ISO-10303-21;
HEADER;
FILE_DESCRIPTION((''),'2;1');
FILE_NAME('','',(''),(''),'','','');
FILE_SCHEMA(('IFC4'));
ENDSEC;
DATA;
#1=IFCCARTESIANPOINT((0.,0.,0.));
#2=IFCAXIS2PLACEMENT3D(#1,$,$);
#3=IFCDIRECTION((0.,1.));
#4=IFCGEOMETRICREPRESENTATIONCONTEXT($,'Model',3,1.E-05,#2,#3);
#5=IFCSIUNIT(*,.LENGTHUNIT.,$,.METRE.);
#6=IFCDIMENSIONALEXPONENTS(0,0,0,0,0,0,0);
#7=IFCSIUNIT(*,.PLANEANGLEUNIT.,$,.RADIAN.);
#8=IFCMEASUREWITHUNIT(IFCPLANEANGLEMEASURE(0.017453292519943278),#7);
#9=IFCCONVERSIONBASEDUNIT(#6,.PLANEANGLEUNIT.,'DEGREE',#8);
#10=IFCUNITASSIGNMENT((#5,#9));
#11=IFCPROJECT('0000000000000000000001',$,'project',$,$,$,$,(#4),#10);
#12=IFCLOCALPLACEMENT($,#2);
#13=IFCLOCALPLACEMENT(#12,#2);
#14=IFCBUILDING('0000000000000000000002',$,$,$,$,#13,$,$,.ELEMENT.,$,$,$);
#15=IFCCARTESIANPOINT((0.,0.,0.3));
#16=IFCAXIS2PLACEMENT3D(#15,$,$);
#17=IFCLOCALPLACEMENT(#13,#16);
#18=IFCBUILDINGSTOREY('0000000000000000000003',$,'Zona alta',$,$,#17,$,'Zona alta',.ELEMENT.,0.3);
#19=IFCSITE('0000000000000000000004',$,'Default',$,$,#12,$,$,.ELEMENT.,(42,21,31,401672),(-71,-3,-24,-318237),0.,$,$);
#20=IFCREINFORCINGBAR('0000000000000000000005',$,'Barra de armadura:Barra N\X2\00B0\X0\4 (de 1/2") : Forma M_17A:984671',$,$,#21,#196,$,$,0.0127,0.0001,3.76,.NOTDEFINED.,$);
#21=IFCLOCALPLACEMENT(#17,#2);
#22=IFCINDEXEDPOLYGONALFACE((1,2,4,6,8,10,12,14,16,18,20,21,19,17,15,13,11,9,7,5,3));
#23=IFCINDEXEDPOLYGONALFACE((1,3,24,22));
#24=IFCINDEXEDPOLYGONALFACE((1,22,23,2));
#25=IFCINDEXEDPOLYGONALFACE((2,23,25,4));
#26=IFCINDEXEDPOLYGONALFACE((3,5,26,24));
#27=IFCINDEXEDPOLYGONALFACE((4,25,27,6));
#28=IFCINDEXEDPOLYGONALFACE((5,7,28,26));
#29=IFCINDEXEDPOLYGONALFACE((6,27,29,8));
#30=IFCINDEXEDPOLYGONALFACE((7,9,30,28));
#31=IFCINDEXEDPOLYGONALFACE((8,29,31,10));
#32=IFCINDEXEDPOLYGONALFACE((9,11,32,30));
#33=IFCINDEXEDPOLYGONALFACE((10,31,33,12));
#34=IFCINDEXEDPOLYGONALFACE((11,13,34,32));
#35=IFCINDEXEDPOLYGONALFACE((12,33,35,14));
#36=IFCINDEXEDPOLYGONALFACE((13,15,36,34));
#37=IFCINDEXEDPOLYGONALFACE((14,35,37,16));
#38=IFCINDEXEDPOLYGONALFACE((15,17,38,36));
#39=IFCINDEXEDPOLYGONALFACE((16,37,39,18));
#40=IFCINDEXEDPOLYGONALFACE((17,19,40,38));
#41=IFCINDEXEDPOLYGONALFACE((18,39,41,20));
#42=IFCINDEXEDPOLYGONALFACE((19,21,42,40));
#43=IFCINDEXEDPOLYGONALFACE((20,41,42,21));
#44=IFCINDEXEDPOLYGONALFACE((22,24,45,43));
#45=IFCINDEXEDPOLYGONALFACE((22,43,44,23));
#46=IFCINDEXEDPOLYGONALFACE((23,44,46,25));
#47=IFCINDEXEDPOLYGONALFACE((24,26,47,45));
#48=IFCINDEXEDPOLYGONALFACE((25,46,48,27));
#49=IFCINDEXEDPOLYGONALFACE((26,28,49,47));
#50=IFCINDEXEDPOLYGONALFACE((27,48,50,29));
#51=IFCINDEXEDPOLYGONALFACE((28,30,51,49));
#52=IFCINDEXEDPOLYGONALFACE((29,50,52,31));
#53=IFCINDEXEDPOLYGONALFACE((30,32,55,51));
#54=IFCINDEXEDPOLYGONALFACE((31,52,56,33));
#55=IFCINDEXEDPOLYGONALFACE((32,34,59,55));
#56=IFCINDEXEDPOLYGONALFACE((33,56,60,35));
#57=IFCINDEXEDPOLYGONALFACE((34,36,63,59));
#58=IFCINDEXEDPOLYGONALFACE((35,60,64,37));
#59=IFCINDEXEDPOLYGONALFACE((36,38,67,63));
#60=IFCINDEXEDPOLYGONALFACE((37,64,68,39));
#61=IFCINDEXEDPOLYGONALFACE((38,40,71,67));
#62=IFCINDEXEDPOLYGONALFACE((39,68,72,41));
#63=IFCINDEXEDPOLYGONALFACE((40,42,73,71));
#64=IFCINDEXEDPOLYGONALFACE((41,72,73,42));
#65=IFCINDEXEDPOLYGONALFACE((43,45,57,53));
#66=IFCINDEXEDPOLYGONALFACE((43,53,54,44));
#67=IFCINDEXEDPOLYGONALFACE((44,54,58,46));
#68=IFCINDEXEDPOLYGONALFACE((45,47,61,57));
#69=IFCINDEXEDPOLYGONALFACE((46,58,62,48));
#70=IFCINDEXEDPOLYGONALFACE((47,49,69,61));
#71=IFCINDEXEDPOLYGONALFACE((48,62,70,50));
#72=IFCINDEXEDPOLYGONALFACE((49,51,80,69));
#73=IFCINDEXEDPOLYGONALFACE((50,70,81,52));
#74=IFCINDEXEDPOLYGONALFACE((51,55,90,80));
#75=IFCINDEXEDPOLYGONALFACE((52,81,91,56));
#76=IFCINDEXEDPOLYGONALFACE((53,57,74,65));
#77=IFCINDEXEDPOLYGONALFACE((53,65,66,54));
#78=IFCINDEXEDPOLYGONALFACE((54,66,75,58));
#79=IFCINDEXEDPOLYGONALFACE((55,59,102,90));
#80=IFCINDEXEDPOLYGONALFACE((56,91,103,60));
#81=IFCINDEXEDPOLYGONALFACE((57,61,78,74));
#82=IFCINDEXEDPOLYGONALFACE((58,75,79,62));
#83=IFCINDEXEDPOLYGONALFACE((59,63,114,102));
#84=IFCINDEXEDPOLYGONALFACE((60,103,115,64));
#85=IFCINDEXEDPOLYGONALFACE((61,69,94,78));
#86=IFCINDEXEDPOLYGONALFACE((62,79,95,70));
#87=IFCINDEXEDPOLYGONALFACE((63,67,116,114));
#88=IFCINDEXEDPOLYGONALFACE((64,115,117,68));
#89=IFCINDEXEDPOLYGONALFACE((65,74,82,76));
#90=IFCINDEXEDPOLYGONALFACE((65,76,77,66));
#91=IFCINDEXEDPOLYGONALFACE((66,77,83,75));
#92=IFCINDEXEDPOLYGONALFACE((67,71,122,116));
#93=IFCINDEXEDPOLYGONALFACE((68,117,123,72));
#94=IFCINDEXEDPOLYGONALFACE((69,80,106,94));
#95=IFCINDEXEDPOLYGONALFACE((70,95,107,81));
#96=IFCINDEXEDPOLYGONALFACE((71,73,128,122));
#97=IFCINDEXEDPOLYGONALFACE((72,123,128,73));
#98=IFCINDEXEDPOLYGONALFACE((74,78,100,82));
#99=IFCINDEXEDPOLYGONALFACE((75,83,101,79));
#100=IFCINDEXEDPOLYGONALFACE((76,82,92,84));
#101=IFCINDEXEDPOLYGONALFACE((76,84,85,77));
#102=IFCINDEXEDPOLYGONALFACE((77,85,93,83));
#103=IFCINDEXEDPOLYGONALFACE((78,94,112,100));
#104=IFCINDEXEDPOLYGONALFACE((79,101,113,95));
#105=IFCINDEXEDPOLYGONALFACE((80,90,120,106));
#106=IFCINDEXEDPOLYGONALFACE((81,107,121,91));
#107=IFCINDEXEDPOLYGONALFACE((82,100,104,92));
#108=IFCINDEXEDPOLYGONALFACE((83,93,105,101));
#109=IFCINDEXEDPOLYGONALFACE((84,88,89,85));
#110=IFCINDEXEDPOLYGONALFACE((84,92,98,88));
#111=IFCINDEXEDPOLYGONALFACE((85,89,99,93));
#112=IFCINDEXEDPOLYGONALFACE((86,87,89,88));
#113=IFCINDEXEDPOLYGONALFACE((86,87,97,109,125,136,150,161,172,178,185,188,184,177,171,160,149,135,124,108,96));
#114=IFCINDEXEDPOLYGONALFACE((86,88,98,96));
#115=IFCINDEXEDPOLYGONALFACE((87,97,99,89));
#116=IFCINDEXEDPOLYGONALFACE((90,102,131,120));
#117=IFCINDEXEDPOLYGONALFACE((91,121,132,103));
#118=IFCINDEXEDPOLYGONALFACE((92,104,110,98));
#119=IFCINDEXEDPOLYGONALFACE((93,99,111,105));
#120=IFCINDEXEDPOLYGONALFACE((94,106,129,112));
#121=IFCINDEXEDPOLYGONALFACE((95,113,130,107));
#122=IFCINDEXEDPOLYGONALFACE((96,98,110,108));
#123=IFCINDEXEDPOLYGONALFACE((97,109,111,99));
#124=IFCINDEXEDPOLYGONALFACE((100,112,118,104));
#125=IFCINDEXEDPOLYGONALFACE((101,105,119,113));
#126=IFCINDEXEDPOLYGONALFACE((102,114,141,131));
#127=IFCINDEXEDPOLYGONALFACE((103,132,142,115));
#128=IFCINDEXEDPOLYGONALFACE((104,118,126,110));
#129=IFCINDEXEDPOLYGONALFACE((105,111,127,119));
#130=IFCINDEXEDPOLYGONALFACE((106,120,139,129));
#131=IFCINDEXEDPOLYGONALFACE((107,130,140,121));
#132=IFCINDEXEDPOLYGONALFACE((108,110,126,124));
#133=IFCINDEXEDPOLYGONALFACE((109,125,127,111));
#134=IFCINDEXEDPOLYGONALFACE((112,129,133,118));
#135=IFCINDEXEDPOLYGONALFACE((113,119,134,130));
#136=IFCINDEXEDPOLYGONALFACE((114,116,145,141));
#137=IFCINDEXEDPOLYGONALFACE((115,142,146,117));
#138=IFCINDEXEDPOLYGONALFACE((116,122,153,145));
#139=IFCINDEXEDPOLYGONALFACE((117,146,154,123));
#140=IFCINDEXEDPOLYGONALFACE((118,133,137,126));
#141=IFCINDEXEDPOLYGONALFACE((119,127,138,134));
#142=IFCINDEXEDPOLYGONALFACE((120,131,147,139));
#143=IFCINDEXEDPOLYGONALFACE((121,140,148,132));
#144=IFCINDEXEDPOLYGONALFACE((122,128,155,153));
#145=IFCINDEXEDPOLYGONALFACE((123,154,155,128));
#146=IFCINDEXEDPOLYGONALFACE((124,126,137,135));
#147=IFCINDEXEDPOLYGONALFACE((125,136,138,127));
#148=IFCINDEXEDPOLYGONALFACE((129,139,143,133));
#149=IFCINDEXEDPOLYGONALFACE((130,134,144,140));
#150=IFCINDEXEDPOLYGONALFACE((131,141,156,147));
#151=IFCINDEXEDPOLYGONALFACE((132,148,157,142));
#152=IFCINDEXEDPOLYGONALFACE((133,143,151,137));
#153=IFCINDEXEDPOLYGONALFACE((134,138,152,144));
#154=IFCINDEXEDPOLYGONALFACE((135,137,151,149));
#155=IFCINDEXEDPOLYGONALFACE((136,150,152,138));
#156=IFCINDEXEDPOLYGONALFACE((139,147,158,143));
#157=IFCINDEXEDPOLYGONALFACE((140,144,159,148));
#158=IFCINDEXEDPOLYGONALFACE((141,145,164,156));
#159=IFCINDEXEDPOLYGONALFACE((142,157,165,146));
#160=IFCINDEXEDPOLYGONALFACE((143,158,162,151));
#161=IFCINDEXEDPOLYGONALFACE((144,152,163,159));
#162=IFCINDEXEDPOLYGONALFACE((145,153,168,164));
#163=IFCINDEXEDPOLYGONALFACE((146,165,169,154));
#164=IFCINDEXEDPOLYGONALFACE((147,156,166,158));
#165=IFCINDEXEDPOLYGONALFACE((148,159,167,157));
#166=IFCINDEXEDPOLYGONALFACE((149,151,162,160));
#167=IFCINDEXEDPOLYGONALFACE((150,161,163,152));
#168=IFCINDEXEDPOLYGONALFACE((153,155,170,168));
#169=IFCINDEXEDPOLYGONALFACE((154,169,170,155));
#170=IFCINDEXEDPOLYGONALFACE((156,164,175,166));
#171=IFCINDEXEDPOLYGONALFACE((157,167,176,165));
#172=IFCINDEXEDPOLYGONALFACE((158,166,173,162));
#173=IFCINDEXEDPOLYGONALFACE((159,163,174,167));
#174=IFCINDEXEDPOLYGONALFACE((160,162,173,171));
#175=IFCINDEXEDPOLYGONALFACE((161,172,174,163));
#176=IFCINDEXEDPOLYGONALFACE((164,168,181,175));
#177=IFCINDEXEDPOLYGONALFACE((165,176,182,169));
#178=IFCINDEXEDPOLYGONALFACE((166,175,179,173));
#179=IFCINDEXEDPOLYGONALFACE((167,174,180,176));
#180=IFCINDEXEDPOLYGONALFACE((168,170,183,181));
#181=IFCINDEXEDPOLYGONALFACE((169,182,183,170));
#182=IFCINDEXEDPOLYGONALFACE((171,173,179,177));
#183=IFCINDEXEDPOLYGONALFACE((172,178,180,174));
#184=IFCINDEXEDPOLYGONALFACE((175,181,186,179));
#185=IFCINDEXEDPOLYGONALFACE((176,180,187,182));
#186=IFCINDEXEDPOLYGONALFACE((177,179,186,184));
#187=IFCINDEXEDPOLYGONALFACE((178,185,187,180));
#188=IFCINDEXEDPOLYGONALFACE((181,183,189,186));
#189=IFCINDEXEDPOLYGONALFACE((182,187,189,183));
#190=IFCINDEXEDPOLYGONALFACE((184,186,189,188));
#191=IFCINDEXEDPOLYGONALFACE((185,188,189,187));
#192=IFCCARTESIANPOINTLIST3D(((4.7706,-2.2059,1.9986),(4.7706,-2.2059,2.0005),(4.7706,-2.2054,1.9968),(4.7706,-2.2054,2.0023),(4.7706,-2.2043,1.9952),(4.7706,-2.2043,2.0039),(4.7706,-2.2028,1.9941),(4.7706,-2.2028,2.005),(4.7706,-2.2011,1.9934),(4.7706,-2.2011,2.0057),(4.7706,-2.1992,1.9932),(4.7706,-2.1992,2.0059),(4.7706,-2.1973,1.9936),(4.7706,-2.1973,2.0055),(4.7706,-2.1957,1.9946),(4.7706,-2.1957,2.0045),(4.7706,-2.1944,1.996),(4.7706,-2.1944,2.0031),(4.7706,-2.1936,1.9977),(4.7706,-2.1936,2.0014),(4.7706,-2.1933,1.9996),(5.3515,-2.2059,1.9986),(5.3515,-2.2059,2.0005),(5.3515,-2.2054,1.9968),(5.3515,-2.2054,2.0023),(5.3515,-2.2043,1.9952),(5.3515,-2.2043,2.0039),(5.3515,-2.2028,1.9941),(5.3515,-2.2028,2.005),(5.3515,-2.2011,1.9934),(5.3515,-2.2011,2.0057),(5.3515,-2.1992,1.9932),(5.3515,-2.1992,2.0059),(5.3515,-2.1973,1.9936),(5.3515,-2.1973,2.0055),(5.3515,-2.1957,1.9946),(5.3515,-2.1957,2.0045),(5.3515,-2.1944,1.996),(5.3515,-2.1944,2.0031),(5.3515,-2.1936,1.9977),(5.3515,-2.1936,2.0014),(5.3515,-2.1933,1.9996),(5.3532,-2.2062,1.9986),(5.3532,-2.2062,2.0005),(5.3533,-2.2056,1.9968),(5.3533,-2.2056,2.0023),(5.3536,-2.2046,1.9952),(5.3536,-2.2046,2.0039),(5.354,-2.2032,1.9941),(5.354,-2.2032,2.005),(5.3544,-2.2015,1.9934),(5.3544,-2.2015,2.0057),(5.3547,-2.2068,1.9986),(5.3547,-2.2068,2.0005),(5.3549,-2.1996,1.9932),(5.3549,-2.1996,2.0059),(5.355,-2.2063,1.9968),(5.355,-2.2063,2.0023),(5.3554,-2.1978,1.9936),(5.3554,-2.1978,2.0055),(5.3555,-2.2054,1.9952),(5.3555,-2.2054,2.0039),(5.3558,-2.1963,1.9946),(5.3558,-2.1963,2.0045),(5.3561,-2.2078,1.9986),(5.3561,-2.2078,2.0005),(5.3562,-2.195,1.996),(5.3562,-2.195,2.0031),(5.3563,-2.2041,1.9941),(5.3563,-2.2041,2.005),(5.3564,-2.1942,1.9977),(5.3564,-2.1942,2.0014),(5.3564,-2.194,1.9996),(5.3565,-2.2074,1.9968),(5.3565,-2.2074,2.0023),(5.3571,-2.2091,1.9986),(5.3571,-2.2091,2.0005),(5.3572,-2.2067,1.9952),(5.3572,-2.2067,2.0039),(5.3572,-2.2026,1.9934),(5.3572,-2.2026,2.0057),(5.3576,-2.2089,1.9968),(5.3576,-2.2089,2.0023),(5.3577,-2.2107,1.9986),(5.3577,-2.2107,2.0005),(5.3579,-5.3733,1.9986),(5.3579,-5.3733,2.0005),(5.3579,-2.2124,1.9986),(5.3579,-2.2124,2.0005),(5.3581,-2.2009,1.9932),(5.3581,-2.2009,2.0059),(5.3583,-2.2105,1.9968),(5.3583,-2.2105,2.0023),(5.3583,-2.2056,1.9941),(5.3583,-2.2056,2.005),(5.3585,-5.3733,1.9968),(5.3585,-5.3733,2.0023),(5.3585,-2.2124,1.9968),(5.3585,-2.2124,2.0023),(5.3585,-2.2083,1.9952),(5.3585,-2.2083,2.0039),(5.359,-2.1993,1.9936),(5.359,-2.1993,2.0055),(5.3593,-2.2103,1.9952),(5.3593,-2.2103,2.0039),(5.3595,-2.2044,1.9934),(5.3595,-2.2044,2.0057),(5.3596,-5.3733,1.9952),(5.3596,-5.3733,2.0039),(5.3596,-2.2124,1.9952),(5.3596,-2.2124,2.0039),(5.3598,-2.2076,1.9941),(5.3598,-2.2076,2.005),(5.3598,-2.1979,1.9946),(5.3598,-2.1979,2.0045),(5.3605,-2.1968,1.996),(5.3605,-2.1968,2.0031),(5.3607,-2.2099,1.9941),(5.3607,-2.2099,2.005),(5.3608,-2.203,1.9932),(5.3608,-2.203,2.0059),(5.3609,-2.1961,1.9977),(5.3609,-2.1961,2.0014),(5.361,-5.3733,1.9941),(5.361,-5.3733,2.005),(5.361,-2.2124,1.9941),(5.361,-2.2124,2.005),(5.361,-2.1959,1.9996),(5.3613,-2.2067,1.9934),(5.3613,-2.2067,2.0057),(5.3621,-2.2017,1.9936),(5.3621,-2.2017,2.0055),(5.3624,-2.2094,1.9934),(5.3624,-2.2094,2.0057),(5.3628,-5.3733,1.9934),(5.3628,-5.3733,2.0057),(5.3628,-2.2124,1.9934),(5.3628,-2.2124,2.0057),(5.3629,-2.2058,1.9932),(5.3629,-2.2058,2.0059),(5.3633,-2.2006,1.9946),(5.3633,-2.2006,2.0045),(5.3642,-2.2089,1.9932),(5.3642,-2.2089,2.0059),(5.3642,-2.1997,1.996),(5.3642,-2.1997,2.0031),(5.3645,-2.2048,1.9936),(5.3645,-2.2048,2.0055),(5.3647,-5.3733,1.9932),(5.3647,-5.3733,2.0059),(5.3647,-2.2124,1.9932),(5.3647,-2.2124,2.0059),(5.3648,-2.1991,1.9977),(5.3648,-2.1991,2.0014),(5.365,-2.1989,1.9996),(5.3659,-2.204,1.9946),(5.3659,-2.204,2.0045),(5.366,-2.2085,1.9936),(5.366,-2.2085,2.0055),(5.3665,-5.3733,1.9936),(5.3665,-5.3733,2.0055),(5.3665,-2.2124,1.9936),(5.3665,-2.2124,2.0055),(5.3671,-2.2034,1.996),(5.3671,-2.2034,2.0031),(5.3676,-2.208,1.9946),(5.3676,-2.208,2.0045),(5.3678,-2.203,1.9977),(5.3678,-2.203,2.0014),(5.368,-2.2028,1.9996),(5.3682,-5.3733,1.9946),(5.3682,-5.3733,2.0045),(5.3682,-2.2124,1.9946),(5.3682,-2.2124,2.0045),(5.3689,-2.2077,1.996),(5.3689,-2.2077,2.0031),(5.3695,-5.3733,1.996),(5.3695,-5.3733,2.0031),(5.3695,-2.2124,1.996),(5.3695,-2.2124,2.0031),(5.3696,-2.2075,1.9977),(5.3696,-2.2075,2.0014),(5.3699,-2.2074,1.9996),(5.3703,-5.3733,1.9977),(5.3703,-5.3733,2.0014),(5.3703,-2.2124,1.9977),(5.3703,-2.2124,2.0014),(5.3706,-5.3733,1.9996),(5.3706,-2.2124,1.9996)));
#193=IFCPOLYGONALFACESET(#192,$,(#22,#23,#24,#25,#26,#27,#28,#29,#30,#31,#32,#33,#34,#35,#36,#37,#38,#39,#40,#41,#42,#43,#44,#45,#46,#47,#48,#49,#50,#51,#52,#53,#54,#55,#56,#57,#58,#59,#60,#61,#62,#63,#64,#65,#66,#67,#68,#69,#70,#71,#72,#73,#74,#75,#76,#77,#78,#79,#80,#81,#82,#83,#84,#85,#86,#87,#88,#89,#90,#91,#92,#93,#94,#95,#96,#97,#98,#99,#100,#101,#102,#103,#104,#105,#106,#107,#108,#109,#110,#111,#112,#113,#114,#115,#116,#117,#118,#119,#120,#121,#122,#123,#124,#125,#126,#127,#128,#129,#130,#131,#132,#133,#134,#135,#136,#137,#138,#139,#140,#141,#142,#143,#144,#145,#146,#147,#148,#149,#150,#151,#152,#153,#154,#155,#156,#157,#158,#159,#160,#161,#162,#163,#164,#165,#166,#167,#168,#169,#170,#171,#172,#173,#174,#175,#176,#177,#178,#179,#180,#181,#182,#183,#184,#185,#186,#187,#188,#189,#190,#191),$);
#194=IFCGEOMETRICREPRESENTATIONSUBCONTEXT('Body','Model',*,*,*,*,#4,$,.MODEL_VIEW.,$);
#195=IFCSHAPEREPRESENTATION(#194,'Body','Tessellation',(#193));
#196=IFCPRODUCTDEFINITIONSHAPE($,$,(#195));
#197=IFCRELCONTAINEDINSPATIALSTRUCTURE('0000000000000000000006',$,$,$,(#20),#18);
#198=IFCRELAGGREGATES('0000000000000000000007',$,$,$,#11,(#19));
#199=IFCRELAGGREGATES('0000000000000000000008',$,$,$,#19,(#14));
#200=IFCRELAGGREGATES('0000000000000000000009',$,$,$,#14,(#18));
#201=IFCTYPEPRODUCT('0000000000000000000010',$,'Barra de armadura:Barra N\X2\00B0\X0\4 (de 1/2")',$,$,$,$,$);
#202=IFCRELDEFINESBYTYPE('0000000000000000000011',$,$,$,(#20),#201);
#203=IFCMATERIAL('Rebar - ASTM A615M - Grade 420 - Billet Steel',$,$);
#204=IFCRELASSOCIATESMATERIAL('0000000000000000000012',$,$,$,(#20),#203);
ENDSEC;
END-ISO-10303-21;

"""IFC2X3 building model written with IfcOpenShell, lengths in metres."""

from ifc_helpers import new_model, entity, si_unit, converted_unit, direction, frame, origin, place, context, subcontext, project, spatial, material, type_object, element, save


model = new_model("IFC2X3")

# Units and contexts
model_context = context("Model", 3, precision=1e-05, world=origin(), true_north=direction((0.0, 1.0)))
body_context = subcontext(model_context, "Body", "Model", "MODEL_VIEW")
ifc_project = project(units=[si_unit("LENGTHUNIT", "METRE"), converted_unit("PLANEANGLEUNIT", "DEGREE", entity("IfcPlaneAngleMeasure", 0.017453292519943278), si_unit("PLANEANGLEUNIT", "RADIAN"), dimensions=[0, 0, 0, 0, 0, 0, 0])], contexts=[model_context])

# Site, building, storey
site_placement = place(None, origin())
site = spatial("IfcSite", under=ifc_project, at=site_placement, Name="Default", CompositionType="ELEMENT", RefLatitude=(42, 21, 31, 401672), RefLongitude=(-71, -3, -24, -318237), RefElevation=0.0)
building_placement = place(site_placement, origin())
building = spatial("IfcBuilding", under=site, at=building_placement, CompositionType="ELEMENT")
storey_placement = place(building_placement, frame((0.0, 0.0, 0.3)))
storey = spatial("IfcBuildingStorey", under=building, at=storey_placement, Name="Zona alta", LongName="Zona alta", CompositionType="ELEMENT", Elevation=0.3)

# Reinforcing bar
ifc_material_1 = material(Name="Rebar - ASTM A615M - Grade 420 - Billet Steel")
type_product_1 = type_object("IfcTypeProduct", Name="Barra de armadura:Barra N°4 (de 1/2\")")
reinforcing_bar_1_placement = place(storey_placement, origin())
element("IfcReinforcingBar", 1, at=reinforcing_bar_1_placement, inside=storey, type_object=type_product_1, material=ifc_material_1, Name="Barra de armadura:Barra N°4 (de 1/2\") : Forma M_17A:984671", BarLength=3.76, BarRole="NOTDEFINED", CrossSectionArea=0.0001, NominalDiameter=0.0127, context=body_context, shape_type="AdvancedSweptSolid", body=[
    entity("IfcSweptDiskSolid", entity("IfcCompositeCurve", [entity("IfcCompositeCurveSegment", "CONTINUOUS", True, entity("IfcPolyline", [entity("IfcCartesianPoint", [5.3642, -5.3733, 1.9996]), entity("IfcCartesianPoint", [5.3642, -2.2124, 1.9996])])), entity("IfcCompositeCurveSegment", "CONTINUOUS", True, entity("IfcTrimmedCurve", entity("IfcCircle", entity("IfcAxis2Placement3D", entity("IfcCartesianPoint", [5.3515, -2.2124, 1.9996]), entity("IfcDirection", [0.0, 0.0, 1.0]), entity("IfcDirection", [0.0, 1.0, 0.0])), 0.0127), [entity("IfcParameterValue", 270.0)], [entity("IfcParameterValue", 360.0)], True, "PARAMETER")), entity("IfcCompositeCurveSegment", "CONTINUOUS", True, entity("IfcPolyline", [entity("IfcCartesianPoint", [5.3515, -2.1997, 1.9996]), entity("IfcCartesianPoint", [4.7706, -2.1997, 1.9996])]))], False), 0.0063, None, 0.0, 92.0),
])

save(model, "model.ifc")
